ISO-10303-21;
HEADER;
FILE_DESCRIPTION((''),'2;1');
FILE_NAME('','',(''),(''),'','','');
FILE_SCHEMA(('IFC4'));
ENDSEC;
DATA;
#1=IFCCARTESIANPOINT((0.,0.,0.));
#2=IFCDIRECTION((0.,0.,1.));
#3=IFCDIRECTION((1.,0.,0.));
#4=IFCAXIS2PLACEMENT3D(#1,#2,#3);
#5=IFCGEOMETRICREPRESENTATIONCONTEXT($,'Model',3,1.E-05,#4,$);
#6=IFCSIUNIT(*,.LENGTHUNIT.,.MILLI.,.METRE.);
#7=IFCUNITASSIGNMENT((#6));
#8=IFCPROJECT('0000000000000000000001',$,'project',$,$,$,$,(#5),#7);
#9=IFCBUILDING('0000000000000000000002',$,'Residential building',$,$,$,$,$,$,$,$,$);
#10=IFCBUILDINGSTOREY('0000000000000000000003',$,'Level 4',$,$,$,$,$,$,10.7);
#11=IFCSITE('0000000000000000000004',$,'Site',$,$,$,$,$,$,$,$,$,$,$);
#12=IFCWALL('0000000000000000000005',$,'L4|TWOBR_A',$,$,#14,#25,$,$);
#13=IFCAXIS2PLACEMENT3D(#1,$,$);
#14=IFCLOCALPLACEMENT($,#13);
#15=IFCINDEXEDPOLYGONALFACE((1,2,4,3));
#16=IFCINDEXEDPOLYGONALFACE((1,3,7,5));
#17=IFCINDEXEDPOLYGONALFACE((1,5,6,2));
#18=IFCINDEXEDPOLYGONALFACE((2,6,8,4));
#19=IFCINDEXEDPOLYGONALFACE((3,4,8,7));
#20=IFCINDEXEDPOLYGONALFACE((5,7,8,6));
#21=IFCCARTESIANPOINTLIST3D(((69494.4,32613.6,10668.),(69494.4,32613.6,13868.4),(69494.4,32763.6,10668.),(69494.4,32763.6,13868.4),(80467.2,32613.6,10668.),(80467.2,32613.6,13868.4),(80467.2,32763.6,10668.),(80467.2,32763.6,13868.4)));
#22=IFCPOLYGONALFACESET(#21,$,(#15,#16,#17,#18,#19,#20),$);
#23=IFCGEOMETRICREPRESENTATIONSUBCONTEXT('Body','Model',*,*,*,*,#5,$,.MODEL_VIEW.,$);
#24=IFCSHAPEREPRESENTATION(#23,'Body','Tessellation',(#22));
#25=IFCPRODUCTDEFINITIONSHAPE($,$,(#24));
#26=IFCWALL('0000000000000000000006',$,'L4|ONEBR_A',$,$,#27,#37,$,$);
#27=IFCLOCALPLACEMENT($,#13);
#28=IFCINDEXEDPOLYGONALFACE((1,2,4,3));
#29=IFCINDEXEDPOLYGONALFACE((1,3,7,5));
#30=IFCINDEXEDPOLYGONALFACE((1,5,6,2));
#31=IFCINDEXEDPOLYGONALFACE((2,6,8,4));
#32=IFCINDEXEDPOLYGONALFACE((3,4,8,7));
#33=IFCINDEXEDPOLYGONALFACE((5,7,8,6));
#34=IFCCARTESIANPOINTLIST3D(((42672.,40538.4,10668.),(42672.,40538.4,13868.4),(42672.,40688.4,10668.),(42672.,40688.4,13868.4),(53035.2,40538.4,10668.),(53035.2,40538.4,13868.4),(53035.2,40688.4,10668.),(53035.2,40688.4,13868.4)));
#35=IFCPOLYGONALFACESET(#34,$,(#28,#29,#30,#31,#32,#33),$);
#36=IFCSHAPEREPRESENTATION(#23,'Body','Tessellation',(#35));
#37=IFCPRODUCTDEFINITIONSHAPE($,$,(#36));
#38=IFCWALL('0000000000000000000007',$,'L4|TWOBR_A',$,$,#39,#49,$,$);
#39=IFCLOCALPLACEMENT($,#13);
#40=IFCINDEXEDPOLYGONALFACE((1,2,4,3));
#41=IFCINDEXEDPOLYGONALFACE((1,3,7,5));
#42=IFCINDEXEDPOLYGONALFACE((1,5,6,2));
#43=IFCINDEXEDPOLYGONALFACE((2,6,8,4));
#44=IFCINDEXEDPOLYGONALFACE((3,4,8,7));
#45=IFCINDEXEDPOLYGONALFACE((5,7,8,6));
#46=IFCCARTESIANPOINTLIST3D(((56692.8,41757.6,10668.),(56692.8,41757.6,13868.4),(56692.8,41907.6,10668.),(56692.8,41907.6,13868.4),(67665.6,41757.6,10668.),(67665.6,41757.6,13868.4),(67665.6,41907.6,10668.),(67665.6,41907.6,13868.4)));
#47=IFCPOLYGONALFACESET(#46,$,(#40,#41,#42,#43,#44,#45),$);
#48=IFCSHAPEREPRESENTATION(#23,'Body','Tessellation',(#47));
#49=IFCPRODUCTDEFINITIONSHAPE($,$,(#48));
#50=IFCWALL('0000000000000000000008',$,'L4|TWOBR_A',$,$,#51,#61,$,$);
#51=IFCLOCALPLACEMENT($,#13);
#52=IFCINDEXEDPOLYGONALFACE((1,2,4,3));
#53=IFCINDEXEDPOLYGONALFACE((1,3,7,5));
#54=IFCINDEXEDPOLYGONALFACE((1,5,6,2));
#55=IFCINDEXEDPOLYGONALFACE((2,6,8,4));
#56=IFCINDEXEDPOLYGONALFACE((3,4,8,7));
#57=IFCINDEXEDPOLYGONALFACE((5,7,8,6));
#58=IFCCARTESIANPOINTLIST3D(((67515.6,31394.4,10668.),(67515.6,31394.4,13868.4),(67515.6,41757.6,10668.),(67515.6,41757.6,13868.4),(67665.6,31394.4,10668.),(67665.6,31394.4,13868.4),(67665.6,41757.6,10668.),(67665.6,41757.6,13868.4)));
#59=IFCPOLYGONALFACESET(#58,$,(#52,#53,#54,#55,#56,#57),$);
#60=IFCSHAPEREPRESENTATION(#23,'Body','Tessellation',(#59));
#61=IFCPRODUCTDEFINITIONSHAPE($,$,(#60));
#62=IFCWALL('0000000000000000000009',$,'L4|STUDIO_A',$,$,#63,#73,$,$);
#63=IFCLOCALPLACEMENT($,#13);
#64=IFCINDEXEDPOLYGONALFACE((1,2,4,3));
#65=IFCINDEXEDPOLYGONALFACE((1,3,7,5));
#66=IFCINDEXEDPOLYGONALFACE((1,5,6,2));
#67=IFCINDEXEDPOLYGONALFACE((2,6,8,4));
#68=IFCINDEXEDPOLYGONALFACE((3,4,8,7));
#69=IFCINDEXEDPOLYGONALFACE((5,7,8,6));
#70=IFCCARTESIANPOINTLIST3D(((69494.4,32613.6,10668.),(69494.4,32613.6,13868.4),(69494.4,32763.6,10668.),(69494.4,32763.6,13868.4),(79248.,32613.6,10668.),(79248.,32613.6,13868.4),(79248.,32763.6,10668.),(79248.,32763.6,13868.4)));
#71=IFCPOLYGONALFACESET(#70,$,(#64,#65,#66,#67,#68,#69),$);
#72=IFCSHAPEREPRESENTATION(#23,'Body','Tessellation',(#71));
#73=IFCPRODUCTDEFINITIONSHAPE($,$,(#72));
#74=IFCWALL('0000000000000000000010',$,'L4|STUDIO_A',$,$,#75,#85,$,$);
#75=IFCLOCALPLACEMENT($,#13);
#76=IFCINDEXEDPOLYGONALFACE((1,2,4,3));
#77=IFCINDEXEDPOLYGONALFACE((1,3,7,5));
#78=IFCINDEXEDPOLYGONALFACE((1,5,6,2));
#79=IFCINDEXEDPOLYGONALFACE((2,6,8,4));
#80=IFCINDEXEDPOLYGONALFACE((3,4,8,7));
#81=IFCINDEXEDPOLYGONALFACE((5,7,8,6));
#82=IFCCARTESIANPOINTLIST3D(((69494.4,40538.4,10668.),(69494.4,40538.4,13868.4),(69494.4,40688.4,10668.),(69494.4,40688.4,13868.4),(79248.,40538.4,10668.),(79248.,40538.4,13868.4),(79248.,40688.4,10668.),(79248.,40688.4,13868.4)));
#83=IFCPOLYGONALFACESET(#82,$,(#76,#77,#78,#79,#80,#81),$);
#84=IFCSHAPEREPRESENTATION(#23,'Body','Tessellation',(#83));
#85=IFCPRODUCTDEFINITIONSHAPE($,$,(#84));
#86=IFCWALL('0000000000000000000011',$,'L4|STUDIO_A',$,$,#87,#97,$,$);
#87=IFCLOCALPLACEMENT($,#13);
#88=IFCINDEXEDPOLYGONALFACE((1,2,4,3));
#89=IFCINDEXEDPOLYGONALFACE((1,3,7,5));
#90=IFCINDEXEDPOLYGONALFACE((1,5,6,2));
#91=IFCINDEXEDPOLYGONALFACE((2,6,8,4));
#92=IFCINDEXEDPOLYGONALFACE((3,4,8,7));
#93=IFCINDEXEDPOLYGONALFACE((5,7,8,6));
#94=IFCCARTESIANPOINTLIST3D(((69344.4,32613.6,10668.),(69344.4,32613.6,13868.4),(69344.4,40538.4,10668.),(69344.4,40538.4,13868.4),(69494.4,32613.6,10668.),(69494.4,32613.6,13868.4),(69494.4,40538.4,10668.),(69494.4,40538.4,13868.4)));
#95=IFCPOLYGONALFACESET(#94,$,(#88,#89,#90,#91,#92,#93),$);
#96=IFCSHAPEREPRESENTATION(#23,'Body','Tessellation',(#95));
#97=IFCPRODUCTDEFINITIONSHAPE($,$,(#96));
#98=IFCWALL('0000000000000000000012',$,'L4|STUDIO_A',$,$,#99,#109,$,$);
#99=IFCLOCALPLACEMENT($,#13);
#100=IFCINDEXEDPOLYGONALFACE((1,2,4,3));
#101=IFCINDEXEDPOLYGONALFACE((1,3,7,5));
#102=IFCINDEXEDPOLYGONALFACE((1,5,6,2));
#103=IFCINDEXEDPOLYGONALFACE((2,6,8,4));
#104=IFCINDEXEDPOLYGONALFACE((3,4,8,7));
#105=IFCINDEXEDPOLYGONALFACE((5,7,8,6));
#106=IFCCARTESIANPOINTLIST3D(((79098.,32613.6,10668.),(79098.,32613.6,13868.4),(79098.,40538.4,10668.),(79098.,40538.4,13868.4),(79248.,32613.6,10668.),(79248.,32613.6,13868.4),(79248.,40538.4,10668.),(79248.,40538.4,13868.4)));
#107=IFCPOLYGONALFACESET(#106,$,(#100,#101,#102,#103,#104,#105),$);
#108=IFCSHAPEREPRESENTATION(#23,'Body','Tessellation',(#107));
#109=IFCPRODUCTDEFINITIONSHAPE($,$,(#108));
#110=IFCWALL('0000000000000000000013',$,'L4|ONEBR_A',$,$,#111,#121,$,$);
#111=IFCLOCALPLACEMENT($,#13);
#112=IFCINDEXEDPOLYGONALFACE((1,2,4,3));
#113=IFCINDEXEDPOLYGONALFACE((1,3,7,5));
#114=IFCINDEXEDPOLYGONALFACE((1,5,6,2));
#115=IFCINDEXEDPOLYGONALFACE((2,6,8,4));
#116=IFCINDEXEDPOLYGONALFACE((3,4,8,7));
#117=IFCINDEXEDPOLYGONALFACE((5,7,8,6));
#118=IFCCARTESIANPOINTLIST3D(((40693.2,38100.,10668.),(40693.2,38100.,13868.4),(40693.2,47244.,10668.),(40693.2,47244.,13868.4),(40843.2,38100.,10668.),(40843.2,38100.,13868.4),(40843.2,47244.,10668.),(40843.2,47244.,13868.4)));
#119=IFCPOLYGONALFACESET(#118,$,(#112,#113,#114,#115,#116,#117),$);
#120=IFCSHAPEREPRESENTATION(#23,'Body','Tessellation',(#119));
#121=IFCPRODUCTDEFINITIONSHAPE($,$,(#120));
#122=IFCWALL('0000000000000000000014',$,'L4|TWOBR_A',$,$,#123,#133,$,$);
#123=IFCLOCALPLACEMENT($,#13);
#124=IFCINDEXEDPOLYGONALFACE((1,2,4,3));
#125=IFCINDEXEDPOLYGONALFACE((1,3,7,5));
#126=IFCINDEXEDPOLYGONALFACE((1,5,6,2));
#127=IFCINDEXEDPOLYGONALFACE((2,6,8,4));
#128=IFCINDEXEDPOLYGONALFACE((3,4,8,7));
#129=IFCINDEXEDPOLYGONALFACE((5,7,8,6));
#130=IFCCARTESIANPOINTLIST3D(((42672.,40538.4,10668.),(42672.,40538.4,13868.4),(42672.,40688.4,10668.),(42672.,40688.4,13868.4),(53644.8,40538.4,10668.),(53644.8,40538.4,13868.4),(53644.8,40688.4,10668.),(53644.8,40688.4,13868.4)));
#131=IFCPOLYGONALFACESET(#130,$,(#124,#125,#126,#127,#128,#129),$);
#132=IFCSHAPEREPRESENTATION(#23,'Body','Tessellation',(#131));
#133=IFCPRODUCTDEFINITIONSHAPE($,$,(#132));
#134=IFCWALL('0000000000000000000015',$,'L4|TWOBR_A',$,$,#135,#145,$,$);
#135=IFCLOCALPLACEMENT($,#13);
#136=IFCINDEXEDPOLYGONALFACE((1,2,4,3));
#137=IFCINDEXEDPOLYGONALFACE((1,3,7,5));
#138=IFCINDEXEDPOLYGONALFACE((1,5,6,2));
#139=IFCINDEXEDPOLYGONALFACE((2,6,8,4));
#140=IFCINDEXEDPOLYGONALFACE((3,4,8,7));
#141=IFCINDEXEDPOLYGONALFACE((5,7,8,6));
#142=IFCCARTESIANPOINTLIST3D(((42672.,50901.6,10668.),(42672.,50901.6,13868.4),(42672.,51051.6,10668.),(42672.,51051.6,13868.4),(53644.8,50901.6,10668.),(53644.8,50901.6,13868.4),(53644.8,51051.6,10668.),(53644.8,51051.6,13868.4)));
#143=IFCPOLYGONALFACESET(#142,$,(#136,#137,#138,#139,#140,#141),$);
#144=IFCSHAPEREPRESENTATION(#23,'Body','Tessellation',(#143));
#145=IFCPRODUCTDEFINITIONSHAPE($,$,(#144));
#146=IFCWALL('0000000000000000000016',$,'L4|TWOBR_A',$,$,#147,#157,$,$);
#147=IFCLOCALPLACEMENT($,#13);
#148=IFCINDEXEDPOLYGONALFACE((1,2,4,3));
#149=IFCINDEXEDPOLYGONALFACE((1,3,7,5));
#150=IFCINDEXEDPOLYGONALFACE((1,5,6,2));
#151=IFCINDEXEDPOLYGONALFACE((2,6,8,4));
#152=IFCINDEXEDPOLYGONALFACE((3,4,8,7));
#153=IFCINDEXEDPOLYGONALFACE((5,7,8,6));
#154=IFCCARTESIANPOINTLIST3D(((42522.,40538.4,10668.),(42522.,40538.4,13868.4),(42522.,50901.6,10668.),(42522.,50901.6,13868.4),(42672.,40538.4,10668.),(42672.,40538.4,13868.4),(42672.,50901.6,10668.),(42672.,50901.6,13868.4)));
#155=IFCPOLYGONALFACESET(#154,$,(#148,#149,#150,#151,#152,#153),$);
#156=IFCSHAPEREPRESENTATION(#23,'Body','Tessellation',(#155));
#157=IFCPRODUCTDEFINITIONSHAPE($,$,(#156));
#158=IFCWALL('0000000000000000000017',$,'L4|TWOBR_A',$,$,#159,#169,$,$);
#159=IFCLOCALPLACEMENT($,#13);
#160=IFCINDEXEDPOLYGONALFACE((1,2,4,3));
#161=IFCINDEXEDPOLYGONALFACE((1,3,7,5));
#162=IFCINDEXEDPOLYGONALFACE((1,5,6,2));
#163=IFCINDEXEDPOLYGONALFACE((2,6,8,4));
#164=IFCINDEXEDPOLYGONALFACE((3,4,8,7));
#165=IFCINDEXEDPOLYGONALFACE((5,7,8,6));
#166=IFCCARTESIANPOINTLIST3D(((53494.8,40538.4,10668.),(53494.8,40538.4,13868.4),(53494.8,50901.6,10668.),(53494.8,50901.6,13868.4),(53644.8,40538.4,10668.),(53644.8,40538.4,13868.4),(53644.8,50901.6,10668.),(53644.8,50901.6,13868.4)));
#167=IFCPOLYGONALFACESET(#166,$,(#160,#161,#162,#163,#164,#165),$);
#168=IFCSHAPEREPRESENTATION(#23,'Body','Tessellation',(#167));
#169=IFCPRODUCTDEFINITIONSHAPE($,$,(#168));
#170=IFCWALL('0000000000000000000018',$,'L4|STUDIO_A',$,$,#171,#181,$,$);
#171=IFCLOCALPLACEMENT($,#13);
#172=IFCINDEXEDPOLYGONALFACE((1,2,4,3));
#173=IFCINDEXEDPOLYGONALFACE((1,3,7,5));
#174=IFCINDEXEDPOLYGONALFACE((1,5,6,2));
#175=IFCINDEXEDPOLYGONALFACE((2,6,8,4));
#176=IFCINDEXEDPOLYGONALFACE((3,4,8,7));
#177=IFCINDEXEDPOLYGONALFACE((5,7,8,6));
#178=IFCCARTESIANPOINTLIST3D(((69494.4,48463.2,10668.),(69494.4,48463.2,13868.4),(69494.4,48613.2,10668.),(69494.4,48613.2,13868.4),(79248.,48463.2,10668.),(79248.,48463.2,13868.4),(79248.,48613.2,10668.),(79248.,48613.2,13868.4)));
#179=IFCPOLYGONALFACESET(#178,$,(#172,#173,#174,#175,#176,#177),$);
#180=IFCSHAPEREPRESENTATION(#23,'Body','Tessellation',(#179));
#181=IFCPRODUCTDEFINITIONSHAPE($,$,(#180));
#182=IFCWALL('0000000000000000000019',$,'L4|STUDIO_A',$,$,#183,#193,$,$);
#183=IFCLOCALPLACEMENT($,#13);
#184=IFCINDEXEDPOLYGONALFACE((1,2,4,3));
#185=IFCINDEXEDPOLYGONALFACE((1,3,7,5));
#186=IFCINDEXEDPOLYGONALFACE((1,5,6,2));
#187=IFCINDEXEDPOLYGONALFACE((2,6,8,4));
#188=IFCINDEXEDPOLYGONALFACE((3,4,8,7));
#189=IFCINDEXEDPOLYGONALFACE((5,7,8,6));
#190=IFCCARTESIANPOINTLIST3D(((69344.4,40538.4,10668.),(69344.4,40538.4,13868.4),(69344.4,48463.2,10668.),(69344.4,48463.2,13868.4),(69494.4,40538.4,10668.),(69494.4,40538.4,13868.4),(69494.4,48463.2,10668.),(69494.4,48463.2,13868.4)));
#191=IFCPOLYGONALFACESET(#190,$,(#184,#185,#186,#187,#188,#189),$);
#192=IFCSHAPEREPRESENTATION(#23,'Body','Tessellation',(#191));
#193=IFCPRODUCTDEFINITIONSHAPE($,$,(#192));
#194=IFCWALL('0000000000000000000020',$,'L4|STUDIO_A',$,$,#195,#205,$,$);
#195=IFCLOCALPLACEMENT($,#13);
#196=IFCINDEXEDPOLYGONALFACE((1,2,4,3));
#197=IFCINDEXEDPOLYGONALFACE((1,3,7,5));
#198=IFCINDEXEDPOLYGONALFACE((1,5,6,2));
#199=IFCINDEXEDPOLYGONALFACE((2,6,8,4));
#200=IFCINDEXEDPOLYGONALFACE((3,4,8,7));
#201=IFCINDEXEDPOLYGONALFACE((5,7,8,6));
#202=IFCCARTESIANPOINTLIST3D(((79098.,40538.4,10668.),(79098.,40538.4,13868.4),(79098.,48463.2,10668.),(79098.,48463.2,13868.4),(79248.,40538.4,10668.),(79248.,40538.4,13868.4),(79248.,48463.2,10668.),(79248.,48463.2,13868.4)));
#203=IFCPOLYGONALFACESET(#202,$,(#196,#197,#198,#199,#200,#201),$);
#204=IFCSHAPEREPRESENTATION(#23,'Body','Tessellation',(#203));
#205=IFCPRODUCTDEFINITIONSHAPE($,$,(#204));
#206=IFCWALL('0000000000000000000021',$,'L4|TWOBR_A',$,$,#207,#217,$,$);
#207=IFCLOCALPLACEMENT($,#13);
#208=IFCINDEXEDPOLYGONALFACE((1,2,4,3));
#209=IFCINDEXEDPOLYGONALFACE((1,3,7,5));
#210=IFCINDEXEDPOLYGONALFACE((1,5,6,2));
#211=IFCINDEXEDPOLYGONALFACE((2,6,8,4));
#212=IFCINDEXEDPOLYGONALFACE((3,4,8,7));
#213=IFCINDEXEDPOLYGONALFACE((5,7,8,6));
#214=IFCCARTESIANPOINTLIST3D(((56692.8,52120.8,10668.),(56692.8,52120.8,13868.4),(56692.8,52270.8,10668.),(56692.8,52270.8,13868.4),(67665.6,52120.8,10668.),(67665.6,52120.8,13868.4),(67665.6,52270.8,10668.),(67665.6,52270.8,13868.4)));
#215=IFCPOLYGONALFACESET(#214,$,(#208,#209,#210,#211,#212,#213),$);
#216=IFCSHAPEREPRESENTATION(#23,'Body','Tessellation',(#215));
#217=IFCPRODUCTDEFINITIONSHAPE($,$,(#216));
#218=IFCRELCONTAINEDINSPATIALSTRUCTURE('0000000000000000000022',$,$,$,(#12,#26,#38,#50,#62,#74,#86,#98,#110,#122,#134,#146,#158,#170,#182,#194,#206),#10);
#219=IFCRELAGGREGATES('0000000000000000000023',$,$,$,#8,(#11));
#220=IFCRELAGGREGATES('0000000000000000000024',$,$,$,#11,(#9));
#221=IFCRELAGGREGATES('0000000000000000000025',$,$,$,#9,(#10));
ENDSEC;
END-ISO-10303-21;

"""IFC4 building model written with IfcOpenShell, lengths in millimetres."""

from ifc_helpers import new_model, si_unit, frame, origin_with_axes, place, context, subcontext, project, spatial, indexed_curve, outline, extrude, element, save


model = new_model("IFC4")

# Units and contexts
model_context = context("Model", 3, precision=1e-05, world=origin_with_axes())
body_context = subcontext(model_context, "Body", "Model", "MODEL_VIEW")
ifc_project = project(units=[si_unit("LENGTHUNIT", "METRE", prefix="MILLI")], contexts=[model_context])

# Site, building, storey
site = spatial("IfcSite", under=ifc_project, Name="Site")
building = spatial("IfcBuilding", under=site, Name="Residential building")
storey = spatial("IfcBuildingStorey", under=building, Name="Level 4", Elevation=10.7)

# Walls
wall_1_placement = place(None, frame((69494.4, 32613.6, 10668.0), z_axis=(0.0, 0.0, 1.0), x_axis=(1.0, 0.0, 0.0)))
element("IfcWall", 1, at=wall_1_placement, inside=storey, Name="L4|TWOBR_A", context=body_context, shape_type="SweptSolid", body=[
    extrude(outline(indexed_curve([(0.0, 0.0), (0.0, 150.0), (10972.8, 150.0), (10972.8, 0.0), (0.0, 0.0)], self_intersect=False)), origin_with_axes(), (0.0, 0.0, 1.0), 3200.4),
])
wall_2_placement = place(None, frame((42672.0, 40538.4, 10668.0), z_axis=(0.0, 0.0, 1.0), x_axis=(1.0, 0.0, 0.0)))
element("IfcWall", 2, at=wall_2_placement, inside=storey, Name="L4|ONEBR_A", context=body_context, shape_type="SweptSolid", body=[
    extrude(outline(indexed_curve([(0.0, 0.0), (0.0, 150.0), (10363.2, 150.0), (10363.2, 0.0), (0.0, 0.0)], self_intersect=False)), origin_with_axes(), (0.0, 0.0, 1.0), 3200.4),
])
wall_3_placement = place(None, frame((56692.8, 41757.6, 10668.0), z_axis=(0.0, 0.0, 1.0), x_axis=(1.0, 0.0, 0.0)))
element("IfcWall", 3, at=wall_3_placement, inside=storey, Name="L4|TWOBR_A", context=body_context, shape_type="SweptSolid", body=[
    extrude(outline(indexed_curve([(0.0, 0.0), (0.0, 150.0), (10972.8, 150.0), (10972.8, 0.0), (0.0, 0.0)], self_intersect=False)), origin_with_axes(), (0.0, 0.0, 1.0), 3200.4),
])
wall_4_placement = place(None, frame((67665.6, 31394.4, 10668.0), z_axis=(0.0, 0.0, 1.0), x_axis=(0.0, 1.0, 0.0)))
element("IfcWall", 4, at=wall_4_placement, inside=storey, Name="L4|TWOBR_A", context=body_context, shape_type="SweptSolid", body=[
    extrude(outline(indexed_curve([(0.0, 0.0), (0.0, 150.0), (10363.2, 150.0), (10363.2, 0.0), (0.0, 0.0)], self_intersect=False)), origin_with_axes(), (0.0, 0.0, 1.0), 3200.4),
])
for number, where, z_axis, x_axis, name in (
    (5, (69494.4, 32613.6, 10668.0), (0.0, 0.0, 1.0), (1.0, 0.0, 0.0), "L4|STUDIO_A"),
    (6, (69494.4, 40538.4, 10668.0), (0.0, 0.0, 1.0), (1.0, 0.0, 0.0), "L4|STUDIO_A"),
):
    element("IfcWall", number, at=place(None, frame(where, z_axis=z_axis, x_axis=x_axis)), inside=storey, Name=name, context=body_context, shape_type="SweptSolid", body=[
        extrude(outline(indexed_curve([(0.0, 0.0), (0.0, 150.0), (9753.6, 150.0), (9753.6, 0.0), (0.0, 0.0)], self_intersect=False)), origin_with_axes(), (0.0, 0.0, 1.0), 3200.4),
    ])
for number, where, z_axis, x_axis, name in (
    (7, (69494.4, 32613.6, 10668.0), (0.0, 0.0, 1.0), (0.0, 1.0, 0.0), "L4|STUDIO_A"),
    (8, (79248.0, 32613.6, 10668.0), (0.0, 0.0, 1.0), (0.0, 1.0, 0.0), "L4|STUDIO_A"),
):
    element("IfcWall", number, at=place(None, frame(where, z_axis=z_axis, x_axis=x_axis)), inside=storey, Name=name, context=body_context, shape_type="SweptSolid", body=[
        extrude(outline(indexed_curve([(0.0, 0.0), (0.0, 150.0), (7924.8, 150.0), (7924.8, 0.0), (0.0, 0.0)], self_intersect=False)), origin_with_axes(), (0.0, 0.0, 1.0), 3200.4),
    ])
wall_5_placement = place(None, frame((40843.2, 38100.0, 10668.0), z_axis=(0.0, 0.0, 1.0), x_axis=(0.0, 1.0, 0.0)))
element("IfcWall", 9, at=wall_5_placement, inside=storey, Name="L4|ONEBR_A", context=body_context, shape_type="SweptSolid", body=[
    extrude(outline(indexed_curve([(0.0, 0.0), (0.0, 150.0), (9144.0, 150.0), (9144.0, 0.0), (0.0, 0.0)], self_intersect=False)), origin_with_axes(), (0.0, 0.0, 1.0), 3200.4),
])
for number, where, z_axis, x_axis, name in (
    (10, (42672.0, 40538.4, 10668.0), (0.0, 0.0, 1.0), (1.0, 0.0, 0.0), "L4|TWOBR_A"),
    (11, (42672.0, 50901.6, 10668.0), (0.0, 0.0, 1.0), (1.0, 0.0, 0.0), "L4|TWOBR_A"),
):
    element("IfcWall", number, at=place(None, frame(where, z_axis=z_axis, x_axis=x_axis)), inside=storey, Name=name, context=body_context, shape_type="SweptSolid", body=[
        extrude(outline(indexed_curve([(0.0, 0.0), (0.0, 150.0), (10972.8, 150.0), (10972.8, 0.0), (0.0, 0.0)], self_intersect=False)), origin_with_axes(), (0.0, 0.0, 1.0), 3200.4),
    ])
for number, where, z_axis, x_axis, name in (
    (12, (42672.0, 40538.4, 10668.0), (0.0, 0.0, 1.0), (0.0, 1.0, 0.0), "L4|TWOBR_A"),
    (13, (53644.8, 40538.4, 10668.0), (0.0, 0.0, 1.0), (0.0, 1.0, 0.0), "L4|TWOBR_A"),
):
    element("IfcWall", number, at=place(None, frame(where, z_axis=z_axis, x_axis=x_axis)), inside=storey, Name=name, context=body_context, shape_type="SweptSolid", body=[
        extrude(outline(indexed_curve([(0.0, 0.0), (0.0, 150.0), (10363.2, 150.0), (10363.2, 0.0), (0.0, 0.0)], self_intersect=False)), origin_with_axes(), (0.0, 0.0, 1.0), 3200.4),
    ])
for number, where, z_axis, x_axis, name in (
    (14, (69494.4, 48463.2, 10668.0), (0.0, 0.0, 1.0), (1.0, 0.0, 0.0), "L4|STUDIO_A"),
):
    element("IfcWall", number, at=place(None, frame(where, z_axis=z_axis, x_axis=x_axis)), inside=storey, Name=name, context=body_context, shape_type="SweptSolid", body=[
        extrude(outline(indexed_curve([(0.0, 0.0), (0.0, 150.0), (9753.6, 150.0), (9753.6, 0.0), (0.0, 0.0)], self_intersect=False)), origin_with_axes(), (0.0, 0.0, 1.0), 3200.4),
    ])
for number, where, z_axis, x_axis, name in (
    (15, (69494.4, 40538.4, 10668.0), (0.0, 0.0, 1.0), (0.0, 1.0, 0.0), "L4|STUDIO_A"),
    (16, (79248.0, 40538.4, 10668.0), (0.0, 0.0, 1.0), (0.0, 1.0, 0.0), "L4|STUDIO_A"),
):
    element("IfcWall", number, at=place(None, frame(where, z_axis=z_axis, x_axis=x_axis)), inside=storey, Name=name, context=body_context, shape_type="SweptSolid", body=[
        extrude(outline(indexed_curve([(0.0, 0.0), (0.0, 150.0), (7924.8, 150.0), (7924.8, 0.0), (0.0, 0.0)], self_intersect=False)), origin_with_axes(), (0.0, 0.0, 1.0), 3200.4),
    ])
for number, where, z_axis, x_axis, name in (
    (17, (56692.8, 52120.8, 10668.0), (0.0, 0.0, 1.0), (1.0, 0.0, 0.0), "L4|TWOBR_A"),
):
    element("IfcWall", number, at=place(None, frame(where, z_axis=z_axis, x_axis=x_axis)), inside=storey, Name=name, context=body_context, shape_type="SweptSolid", body=[
        extrude(outline(indexed_curve([(0.0, 0.0), (0.0, 150.0), (10972.8, 150.0), (10972.8, 0.0), (0.0, 0.0)], self_intersect=False)), origin_with_axes(), (0.0, 0.0, 1.0), 3200.4),
    ])

save(model, "model.ifc")
